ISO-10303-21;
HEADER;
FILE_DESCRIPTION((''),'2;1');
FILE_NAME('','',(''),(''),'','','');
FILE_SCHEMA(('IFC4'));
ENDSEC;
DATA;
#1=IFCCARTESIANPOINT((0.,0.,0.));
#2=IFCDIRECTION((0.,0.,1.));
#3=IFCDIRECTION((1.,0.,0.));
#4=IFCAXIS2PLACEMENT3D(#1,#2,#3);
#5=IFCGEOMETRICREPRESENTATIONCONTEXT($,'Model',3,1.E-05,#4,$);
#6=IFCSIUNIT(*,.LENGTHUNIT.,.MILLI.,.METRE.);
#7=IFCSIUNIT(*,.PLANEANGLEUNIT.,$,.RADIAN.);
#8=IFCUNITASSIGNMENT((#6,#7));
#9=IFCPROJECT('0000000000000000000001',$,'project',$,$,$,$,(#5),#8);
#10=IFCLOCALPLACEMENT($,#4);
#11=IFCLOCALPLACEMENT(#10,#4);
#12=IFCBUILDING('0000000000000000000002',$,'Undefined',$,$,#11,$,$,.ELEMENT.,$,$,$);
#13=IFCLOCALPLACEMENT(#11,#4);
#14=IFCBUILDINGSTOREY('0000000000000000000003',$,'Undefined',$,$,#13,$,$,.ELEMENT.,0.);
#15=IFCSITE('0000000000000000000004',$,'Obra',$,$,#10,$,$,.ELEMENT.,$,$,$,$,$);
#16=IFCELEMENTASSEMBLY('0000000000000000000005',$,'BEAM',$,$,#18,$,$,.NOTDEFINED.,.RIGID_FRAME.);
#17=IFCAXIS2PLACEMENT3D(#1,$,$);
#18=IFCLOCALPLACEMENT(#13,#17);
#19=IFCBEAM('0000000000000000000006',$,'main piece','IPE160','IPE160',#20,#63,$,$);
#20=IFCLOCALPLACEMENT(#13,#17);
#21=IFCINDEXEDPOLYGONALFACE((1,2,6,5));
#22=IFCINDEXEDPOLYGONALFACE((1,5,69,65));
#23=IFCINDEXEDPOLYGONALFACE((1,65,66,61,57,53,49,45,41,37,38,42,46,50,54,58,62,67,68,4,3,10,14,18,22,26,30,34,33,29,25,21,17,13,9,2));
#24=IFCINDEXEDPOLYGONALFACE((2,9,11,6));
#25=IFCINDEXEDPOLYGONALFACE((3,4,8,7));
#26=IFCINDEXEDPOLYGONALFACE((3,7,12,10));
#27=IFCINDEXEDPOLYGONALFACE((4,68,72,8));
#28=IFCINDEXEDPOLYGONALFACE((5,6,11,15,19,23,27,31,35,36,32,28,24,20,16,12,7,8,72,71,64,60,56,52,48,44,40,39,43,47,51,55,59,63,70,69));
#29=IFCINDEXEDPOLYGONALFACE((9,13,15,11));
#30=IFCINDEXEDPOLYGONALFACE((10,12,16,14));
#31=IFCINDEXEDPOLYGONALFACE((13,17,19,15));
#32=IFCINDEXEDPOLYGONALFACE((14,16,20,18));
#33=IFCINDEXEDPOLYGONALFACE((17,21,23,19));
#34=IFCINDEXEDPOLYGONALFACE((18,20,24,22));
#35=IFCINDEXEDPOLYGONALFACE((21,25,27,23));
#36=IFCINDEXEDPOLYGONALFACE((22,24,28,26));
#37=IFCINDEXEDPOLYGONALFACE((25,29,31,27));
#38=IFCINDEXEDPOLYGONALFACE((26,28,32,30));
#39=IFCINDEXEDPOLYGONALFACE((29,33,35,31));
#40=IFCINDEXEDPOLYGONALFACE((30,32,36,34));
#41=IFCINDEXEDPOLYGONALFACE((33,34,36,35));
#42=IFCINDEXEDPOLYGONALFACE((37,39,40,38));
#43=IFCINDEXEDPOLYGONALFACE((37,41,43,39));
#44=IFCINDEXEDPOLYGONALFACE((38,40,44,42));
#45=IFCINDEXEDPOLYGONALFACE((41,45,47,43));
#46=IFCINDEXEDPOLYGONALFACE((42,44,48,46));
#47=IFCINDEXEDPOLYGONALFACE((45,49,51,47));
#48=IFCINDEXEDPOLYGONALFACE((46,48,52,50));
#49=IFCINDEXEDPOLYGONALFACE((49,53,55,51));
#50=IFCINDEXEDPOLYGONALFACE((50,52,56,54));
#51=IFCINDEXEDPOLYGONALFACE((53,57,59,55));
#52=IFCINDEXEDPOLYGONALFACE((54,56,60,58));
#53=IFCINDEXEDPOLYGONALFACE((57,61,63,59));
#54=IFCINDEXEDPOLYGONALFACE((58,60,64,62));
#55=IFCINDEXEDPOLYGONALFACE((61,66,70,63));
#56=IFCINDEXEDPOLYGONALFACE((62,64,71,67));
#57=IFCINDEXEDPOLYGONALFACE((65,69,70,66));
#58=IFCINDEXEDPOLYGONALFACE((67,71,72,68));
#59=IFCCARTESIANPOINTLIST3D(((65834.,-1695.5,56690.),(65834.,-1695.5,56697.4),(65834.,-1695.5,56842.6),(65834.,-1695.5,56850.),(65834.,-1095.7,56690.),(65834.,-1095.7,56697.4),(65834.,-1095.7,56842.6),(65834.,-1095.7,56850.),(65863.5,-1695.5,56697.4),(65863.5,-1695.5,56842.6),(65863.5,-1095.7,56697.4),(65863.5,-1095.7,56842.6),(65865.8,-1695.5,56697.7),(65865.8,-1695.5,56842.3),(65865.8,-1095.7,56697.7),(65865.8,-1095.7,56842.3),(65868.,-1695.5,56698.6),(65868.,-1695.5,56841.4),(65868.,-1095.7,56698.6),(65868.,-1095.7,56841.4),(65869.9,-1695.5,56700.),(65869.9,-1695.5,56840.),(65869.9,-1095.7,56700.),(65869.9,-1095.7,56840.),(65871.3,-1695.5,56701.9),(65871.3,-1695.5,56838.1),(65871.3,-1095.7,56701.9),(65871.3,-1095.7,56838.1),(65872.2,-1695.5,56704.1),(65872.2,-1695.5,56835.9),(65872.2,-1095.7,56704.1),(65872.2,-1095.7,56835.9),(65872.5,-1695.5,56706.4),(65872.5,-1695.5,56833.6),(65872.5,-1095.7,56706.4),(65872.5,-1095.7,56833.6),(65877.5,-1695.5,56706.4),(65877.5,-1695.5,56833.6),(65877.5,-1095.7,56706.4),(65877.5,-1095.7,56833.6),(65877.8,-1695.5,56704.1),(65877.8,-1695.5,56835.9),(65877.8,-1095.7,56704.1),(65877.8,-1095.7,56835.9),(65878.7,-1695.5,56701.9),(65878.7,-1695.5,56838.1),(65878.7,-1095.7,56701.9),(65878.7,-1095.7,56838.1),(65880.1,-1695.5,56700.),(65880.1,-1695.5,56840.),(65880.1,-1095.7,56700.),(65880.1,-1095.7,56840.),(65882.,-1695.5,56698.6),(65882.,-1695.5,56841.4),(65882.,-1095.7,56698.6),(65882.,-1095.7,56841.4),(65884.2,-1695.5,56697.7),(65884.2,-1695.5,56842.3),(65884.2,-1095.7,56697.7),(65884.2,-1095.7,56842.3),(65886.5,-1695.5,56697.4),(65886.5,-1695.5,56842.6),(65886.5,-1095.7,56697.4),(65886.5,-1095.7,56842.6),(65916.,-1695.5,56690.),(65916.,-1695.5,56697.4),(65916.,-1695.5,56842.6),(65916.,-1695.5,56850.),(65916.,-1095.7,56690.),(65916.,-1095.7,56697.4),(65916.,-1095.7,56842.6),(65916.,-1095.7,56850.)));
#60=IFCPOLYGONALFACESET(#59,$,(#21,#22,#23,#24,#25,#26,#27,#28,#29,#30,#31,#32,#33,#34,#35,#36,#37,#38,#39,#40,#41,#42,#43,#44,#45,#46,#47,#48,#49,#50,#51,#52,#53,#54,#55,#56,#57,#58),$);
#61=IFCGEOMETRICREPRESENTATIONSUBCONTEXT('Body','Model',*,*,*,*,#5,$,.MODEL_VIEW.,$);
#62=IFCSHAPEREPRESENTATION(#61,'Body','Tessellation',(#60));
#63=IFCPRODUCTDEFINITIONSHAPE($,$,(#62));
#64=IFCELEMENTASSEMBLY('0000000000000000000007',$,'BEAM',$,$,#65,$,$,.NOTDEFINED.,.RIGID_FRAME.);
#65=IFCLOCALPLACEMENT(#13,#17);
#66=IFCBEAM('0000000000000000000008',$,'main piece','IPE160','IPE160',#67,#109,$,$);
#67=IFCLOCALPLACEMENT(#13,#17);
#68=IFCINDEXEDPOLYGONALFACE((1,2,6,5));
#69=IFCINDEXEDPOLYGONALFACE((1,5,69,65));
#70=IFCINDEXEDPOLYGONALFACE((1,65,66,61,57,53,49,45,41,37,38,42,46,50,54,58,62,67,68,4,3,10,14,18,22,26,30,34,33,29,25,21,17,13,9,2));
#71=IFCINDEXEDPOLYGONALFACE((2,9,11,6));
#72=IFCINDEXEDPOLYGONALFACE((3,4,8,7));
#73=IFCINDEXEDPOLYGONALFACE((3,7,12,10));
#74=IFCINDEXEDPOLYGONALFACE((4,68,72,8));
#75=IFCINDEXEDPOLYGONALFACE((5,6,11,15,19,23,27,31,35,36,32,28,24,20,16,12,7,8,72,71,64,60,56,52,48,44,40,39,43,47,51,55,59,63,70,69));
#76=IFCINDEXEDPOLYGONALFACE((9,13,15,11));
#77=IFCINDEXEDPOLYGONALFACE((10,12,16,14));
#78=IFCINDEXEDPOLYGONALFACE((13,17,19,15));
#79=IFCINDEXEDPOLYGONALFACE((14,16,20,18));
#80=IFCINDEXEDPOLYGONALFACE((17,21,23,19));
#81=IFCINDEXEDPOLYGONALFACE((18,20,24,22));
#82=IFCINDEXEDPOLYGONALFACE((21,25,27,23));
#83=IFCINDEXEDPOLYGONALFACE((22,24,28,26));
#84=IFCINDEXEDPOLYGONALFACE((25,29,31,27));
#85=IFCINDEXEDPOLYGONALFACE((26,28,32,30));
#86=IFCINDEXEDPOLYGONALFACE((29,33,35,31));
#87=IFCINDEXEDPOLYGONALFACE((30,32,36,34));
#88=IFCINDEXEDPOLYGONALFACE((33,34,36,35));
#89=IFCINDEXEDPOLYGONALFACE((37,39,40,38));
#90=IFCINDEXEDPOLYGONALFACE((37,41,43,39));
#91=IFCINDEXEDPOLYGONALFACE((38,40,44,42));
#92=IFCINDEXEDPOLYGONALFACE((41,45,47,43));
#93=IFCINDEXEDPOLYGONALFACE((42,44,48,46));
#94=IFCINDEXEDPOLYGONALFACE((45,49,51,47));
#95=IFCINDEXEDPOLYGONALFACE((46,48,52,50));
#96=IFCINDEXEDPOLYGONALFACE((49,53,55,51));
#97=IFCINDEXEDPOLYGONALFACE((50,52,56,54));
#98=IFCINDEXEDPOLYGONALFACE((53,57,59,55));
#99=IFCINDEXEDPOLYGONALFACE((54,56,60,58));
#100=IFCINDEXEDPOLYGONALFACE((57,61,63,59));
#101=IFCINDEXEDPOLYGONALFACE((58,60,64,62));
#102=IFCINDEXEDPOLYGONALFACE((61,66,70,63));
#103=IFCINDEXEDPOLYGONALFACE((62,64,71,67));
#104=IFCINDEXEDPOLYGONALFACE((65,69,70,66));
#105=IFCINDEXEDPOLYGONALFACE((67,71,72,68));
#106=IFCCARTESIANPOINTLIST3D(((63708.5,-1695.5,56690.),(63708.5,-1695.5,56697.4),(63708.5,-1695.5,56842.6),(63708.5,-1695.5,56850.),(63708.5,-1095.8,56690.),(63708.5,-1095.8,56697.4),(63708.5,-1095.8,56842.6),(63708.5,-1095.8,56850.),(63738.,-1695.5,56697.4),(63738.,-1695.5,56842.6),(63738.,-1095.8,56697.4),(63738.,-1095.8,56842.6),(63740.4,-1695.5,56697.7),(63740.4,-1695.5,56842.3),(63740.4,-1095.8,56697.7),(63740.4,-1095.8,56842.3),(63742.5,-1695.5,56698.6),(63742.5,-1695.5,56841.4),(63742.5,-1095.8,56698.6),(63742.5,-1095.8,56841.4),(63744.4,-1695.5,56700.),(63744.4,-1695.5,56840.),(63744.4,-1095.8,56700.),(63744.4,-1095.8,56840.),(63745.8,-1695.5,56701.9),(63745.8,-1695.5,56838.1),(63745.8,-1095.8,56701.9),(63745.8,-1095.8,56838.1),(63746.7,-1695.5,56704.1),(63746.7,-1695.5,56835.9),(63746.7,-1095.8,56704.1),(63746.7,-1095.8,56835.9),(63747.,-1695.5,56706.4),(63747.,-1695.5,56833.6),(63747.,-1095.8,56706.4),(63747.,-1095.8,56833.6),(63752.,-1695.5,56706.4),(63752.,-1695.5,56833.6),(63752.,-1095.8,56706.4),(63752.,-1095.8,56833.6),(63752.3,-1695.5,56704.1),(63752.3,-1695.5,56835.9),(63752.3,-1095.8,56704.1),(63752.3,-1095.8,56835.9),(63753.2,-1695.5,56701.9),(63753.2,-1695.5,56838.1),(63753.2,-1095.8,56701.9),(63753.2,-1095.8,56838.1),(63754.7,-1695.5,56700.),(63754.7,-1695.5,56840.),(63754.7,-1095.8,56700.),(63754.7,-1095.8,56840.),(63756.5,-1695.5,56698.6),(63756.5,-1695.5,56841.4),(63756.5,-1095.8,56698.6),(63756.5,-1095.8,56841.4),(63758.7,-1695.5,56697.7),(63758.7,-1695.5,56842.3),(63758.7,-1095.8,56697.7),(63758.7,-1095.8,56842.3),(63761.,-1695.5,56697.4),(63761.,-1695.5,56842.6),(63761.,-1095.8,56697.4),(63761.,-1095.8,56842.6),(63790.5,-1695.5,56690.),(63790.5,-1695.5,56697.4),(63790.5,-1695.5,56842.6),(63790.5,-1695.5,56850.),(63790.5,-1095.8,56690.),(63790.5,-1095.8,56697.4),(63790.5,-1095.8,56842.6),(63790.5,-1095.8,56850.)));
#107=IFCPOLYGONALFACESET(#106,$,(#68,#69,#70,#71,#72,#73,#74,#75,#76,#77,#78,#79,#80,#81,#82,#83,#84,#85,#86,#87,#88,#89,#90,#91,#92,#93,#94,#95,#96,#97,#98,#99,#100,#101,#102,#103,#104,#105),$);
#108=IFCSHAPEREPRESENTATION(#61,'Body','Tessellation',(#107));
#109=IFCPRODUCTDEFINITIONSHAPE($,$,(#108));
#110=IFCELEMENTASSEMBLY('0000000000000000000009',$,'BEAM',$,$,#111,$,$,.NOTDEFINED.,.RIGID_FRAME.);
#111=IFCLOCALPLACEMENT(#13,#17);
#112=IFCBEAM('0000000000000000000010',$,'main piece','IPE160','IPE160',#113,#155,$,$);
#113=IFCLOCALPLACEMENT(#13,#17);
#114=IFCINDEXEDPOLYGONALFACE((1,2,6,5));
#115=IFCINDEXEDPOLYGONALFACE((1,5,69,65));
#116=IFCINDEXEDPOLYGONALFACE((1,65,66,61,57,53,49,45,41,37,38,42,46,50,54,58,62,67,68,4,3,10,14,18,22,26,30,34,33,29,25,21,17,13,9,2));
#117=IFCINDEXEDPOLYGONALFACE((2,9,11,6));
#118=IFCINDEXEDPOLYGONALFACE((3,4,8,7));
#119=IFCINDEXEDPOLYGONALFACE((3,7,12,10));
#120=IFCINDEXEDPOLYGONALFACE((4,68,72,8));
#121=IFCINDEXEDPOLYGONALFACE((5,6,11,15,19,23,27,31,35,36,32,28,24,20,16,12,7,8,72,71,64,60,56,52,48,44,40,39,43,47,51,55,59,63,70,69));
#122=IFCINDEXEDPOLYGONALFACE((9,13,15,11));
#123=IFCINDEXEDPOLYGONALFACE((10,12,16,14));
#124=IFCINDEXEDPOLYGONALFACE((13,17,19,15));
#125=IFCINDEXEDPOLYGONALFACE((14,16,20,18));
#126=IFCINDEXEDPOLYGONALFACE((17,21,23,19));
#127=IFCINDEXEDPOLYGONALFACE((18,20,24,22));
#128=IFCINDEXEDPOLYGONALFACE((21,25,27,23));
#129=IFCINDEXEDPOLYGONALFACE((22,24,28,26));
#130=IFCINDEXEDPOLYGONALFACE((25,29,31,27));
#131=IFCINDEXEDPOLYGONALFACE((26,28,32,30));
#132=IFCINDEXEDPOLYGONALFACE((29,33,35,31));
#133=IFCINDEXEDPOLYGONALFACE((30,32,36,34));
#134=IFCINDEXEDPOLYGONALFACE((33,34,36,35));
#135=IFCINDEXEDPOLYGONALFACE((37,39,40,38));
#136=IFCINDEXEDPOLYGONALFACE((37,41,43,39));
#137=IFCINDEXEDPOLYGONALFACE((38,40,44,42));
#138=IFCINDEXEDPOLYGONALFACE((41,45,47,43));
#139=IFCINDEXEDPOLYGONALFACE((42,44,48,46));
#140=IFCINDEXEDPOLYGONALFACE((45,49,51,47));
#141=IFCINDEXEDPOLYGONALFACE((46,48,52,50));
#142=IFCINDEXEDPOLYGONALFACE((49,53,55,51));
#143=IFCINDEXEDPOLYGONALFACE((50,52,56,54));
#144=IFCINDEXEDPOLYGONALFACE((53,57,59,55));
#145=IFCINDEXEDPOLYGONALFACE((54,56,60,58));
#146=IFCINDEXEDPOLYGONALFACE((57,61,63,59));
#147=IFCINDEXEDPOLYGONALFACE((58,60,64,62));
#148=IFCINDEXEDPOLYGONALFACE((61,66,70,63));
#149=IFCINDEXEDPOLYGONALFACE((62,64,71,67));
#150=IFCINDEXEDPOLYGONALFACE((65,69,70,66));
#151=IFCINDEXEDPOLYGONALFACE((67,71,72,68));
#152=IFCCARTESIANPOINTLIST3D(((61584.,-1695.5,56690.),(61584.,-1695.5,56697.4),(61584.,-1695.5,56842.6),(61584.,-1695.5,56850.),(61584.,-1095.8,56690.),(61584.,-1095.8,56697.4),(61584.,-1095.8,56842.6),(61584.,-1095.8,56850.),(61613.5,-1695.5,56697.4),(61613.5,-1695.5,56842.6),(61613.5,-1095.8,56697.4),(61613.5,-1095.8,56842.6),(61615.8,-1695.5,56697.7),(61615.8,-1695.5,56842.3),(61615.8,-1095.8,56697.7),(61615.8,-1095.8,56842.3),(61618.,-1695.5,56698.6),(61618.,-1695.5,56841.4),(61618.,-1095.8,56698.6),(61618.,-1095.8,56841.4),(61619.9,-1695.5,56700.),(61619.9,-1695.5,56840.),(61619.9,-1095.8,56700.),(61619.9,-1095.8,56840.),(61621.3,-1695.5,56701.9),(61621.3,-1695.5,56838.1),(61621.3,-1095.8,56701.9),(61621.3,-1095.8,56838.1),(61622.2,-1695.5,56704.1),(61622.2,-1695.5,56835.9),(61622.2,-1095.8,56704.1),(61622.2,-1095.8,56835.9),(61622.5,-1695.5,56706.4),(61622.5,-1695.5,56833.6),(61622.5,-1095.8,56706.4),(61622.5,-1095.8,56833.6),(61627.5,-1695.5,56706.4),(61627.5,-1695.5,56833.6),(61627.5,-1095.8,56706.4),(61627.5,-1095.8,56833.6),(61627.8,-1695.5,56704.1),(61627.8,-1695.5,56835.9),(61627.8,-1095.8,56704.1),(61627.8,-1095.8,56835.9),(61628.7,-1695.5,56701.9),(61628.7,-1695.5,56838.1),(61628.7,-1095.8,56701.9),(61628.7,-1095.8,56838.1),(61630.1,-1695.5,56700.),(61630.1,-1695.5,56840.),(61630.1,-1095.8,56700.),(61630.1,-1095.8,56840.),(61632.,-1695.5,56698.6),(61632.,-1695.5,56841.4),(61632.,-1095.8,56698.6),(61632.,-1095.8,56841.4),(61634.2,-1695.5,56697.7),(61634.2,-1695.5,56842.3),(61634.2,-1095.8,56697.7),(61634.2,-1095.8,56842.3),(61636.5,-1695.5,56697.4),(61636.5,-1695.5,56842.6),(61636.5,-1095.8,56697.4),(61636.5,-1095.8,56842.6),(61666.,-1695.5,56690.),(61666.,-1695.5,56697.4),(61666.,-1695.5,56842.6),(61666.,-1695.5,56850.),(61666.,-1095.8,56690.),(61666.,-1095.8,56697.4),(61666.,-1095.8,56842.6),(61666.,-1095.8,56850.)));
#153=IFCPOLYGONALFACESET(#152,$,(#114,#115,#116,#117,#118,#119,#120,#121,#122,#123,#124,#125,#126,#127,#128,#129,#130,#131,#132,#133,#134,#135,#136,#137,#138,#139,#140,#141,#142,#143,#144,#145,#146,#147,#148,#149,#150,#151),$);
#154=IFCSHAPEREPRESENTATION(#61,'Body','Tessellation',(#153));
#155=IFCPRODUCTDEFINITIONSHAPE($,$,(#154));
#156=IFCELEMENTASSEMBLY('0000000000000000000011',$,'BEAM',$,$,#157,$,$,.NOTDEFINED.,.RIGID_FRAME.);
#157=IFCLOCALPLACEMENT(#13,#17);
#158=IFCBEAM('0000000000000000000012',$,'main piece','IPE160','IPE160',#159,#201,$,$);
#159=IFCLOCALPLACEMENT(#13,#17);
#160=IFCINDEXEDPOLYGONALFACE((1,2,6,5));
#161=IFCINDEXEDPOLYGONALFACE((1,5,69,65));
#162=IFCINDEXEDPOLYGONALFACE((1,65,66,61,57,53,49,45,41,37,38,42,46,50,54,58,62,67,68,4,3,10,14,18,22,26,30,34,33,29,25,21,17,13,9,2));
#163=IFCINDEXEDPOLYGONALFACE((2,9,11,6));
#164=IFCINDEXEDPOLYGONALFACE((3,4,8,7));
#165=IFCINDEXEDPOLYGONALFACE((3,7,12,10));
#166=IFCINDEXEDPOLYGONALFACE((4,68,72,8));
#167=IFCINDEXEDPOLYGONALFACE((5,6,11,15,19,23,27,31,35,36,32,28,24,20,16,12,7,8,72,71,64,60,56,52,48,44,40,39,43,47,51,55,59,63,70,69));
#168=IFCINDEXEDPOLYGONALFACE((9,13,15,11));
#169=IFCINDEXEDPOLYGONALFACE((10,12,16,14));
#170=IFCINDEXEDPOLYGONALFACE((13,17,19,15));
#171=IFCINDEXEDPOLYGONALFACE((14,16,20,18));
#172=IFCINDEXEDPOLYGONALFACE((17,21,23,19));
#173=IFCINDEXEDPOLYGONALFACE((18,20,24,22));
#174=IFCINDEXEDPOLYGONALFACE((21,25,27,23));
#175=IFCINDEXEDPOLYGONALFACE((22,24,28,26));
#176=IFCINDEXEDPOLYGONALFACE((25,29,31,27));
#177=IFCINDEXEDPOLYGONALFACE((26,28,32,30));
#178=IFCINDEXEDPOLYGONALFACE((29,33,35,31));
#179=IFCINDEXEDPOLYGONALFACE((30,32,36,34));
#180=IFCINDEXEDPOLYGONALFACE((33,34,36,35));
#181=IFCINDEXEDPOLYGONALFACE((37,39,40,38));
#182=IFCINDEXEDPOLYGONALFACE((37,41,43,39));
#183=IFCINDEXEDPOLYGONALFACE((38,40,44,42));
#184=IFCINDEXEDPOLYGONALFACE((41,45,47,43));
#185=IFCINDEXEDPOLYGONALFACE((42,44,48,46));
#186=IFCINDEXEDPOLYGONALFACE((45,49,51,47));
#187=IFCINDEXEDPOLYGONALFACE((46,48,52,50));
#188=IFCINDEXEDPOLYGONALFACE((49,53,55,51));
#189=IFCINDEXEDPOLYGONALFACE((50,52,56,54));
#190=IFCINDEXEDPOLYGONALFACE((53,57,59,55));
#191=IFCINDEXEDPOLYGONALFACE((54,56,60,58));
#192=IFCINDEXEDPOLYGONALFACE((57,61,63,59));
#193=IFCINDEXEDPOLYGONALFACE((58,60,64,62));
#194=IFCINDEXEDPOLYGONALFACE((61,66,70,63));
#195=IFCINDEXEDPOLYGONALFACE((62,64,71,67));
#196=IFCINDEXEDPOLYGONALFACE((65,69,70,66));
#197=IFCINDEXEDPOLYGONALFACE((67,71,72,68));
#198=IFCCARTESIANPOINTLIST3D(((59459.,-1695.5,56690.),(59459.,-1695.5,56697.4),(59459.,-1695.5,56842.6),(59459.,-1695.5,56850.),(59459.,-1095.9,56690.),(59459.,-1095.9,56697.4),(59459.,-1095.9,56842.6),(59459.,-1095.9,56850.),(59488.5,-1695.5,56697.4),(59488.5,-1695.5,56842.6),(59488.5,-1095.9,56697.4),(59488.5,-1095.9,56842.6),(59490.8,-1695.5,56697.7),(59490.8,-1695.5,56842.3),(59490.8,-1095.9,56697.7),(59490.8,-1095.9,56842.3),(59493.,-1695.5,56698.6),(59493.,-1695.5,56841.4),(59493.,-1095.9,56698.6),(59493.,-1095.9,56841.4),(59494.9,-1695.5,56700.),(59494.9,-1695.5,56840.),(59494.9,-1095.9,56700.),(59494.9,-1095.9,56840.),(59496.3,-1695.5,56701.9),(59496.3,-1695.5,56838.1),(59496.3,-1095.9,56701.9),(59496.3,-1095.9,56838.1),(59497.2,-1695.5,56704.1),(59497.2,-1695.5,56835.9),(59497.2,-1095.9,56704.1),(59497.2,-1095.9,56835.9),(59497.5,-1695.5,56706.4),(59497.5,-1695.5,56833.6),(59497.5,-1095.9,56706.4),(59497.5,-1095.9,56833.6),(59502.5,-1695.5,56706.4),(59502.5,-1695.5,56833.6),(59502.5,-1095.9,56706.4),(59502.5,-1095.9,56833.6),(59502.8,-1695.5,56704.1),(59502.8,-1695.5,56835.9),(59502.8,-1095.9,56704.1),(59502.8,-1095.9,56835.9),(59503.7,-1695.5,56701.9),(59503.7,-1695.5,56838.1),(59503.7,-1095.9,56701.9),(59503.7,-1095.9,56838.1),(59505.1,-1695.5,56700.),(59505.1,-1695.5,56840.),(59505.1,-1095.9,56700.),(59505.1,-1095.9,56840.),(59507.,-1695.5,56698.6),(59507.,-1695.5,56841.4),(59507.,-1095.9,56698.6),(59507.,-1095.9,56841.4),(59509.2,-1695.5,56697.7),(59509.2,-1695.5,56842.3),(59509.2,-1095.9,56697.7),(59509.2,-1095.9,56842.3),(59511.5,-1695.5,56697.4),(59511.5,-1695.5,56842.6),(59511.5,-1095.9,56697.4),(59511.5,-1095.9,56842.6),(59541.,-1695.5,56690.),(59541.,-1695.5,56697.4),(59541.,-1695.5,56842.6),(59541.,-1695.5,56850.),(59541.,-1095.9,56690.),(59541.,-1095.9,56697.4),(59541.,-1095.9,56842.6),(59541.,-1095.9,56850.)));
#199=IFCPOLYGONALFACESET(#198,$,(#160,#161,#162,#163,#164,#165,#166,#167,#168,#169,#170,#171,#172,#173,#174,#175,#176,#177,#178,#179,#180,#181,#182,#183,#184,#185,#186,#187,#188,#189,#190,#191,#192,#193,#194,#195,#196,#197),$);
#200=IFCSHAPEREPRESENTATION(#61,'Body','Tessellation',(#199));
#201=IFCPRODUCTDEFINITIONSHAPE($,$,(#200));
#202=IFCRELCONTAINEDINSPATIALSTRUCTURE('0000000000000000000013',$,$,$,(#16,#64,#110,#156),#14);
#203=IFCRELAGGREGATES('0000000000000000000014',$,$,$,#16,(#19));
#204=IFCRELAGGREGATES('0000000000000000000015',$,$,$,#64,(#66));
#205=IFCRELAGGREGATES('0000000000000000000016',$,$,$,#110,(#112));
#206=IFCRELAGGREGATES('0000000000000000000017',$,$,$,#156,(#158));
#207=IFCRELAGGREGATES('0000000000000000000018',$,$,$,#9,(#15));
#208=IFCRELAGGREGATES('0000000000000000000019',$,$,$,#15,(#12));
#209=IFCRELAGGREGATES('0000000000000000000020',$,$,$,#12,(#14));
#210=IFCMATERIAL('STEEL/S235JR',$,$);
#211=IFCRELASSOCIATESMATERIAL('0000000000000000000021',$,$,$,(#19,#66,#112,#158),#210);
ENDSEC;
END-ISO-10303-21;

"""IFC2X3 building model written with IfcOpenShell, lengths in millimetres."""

from ifc_helpers import new_model, si_unit, frame, origin_with_axes, origin_2d_with_axis, place, context, subcontext, project, spatial, i_section, extrude, material, element, aggregate, save


model = new_model("IFC2X3")

# Units and contexts
model_context = context("Model", 3, precision=1e-05, world=origin_with_axes())
body_context = subcontext(model_context, "Body", "Model", "MODEL_VIEW")
ifc_project = project(units=[si_unit("LENGTHUNIT", "METRE", prefix="MILLI"), si_unit("PLANEANGLEUNIT", "RADIAN")], contexts=[model_context])

# Site, building, storey
site_placement = place(None, origin_with_axes())
site = spatial("IfcSite", under=ifc_project, at=site_placement, Name="Obra", CompositionType="ELEMENT")
building_placement = place(site_placement, origin_with_axes())
building = spatial("IfcBuilding", under=site, at=building_placement, Name="Undefined", CompositionType="ELEMENT")
storey_placement = place(building_placement, origin_with_axes())
storey = spatial("IfcBuildingStorey", under=building, at=storey_placement, Name="Undefined", CompositionType="ELEMENT", Elevation=0.0)

# Element assemblies, beams
assembly_1_placement = place(storey_placement, origin_with_axes())
assembly_1 = element("IfcElementAssembly", 1, at=assembly_1_placement, inside=storey, Name="BEAM", AssemblyPlace="NOTDEFINED", PredefinedType="RIGID_FRAME")
ifc_material_1 = material(Name="STEEL/S235JR")
beam_1_placement = place(assembly_1_placement, frame((65875.0, -1095.7, 56770.0), z_axis=(0.0, 0.0, 1.0), x_axis=(0.0, -1.0, 0.0)))
beam_1 = element("IfcBeam", 2, at=beam_1_placement, material=ifc_material_1, Name="main piece", Description="IPE160", ObjectType="IPE160", context=body_context, shape_type="SweptSolid", body=[
    extrude(i_section(OverallWidth=82.0, OverallDepth=160.0, WebThickness=5.0, FlangeThickness=7.4, FilletRadius=9.0, at=origin_2d_with_axis()), frame((599.8, 0.0, 0.0), z_axis=(-1.0, 0.0, 0.0), x_axis=(0.0, -1.0, 0.0)), (0.0, 0.0, 1.0), 599.8),
])
aggregate(assembly_1, [beam_1])
assembly_2_placement = place(storey_placement, origin_with_axes())
assembly_2 = element("IfcElementAssembly", 3, at=assembly_2_placement, inside=storey, Name="BEAM", AssemblyPlace="NOTDEFINED", PredefinedType="RIGID_FRAME")
beam_2_placement = place(assembly_2_placement, frame((63749.5, -1095.8, 56770.0), z_axis=(0.0, 0.0, 1.0), x_axis=(0.0, -1.0, 0.0)))
beam_2 = element("IfcBeam", 4, at=beam_2_placement, material=ifc_material_1, Name="main piece", Description="IPE160", ObjectType="IPE160", context=body_context, shape_type="SweptSolid", body=[
    extrude(i_section(OverallWidth=82.0, OverallDepth=160.0, WebThickness=5.0, FlangeThickness=7.4, FilletRadius=9.0, at=origin_2d_with_axis()), frame((599.7, 0.0, 0.0), z_axis=(-1.0, 0.0, 0.0), x_axis=(0.0, -1.0, 0.0)), (0.0, 0.0, 1.0), 599.7),
])
aggregate(assembly_2, [beam_2])
assembly_3_placement = place(storey_placement, origin_with_axes())
assembly_3 = element("IfcElementAssembly", 5, at=assembly_3_placement, inside=storey, Name="BEAM", AssemblyPlace="NOTDEFINED", PredefinedType="RIGID_FRAME")
beam_3_placement = place(assembly_3_placement, frame((61625.0, -1095.8, 56770.0), z_axis=(0.0, 0.0, 1.0), x_axis=(0.0, -1.0, 0.0)))
beam_3 = element("IfcBeam", 6, at=beam_3_placement, material=ifc_material_1, Name="main piece", Description="IPE160", ObjectType="IPE160", context=body_context, shape_type="SweptSolid", body=[
    extrude(i_section(OverallWidth=82.0, OverallDepth=160.0, WebThickness=5.0, FlangeThickness=7.4, FilletRadius=9.0, at=origin_2d_with_axis()), frame((599.7, 0.0, 0.0), z_axis=(-1.0, 0.0, 0.0), x_axis=(0.0, -1.0, 0.0)), (0.0, 0.0, 1.0), 599.7),
])
aggregate(assembly_3, [beam_3])
assembly_4_placement = place(storey_placement, origin_with_axes())
assembly_4 = element("IfcElementAssembly", 7, at=assembly_4_placement, inside=storey, Name="BEAM", AssemblyPlace="NOTDEFINED", PredefinedType="RIGID_FRAME")
beam_4_placement = place(assembly_4_placement, frame((59500.0, -1095.9, 56770.0), z_axis=(0.0, 0.0, 1.0), x_axis=(0.0, -1.0, 0.0)))
beam_4 = element("IfcBeam", 8, at=beam_4_placement, material=ifc_material_1, Name="main piece", Description="IPE160", ObjectType="IPE160", context=body_context, shape_type="SweptSolid", body=[
    extrude(i_section(OverallWidth=82.0, OverallDepth=160.0, WebThickness=5.0, FlangeThickness=7.4, FilletRadius=9.0, at=origin_2d_with_axis()), frame((599.6, 0.0, 0.0), z_axis=(-1.0, 0.0, 0.0), x_axis=(0.0, -1.0, 0.0)), (0.0, 0.0, 1.0), 599.6),
])
aggregate(assembly_4, [beam_4])

save(model, "model.ifc")
